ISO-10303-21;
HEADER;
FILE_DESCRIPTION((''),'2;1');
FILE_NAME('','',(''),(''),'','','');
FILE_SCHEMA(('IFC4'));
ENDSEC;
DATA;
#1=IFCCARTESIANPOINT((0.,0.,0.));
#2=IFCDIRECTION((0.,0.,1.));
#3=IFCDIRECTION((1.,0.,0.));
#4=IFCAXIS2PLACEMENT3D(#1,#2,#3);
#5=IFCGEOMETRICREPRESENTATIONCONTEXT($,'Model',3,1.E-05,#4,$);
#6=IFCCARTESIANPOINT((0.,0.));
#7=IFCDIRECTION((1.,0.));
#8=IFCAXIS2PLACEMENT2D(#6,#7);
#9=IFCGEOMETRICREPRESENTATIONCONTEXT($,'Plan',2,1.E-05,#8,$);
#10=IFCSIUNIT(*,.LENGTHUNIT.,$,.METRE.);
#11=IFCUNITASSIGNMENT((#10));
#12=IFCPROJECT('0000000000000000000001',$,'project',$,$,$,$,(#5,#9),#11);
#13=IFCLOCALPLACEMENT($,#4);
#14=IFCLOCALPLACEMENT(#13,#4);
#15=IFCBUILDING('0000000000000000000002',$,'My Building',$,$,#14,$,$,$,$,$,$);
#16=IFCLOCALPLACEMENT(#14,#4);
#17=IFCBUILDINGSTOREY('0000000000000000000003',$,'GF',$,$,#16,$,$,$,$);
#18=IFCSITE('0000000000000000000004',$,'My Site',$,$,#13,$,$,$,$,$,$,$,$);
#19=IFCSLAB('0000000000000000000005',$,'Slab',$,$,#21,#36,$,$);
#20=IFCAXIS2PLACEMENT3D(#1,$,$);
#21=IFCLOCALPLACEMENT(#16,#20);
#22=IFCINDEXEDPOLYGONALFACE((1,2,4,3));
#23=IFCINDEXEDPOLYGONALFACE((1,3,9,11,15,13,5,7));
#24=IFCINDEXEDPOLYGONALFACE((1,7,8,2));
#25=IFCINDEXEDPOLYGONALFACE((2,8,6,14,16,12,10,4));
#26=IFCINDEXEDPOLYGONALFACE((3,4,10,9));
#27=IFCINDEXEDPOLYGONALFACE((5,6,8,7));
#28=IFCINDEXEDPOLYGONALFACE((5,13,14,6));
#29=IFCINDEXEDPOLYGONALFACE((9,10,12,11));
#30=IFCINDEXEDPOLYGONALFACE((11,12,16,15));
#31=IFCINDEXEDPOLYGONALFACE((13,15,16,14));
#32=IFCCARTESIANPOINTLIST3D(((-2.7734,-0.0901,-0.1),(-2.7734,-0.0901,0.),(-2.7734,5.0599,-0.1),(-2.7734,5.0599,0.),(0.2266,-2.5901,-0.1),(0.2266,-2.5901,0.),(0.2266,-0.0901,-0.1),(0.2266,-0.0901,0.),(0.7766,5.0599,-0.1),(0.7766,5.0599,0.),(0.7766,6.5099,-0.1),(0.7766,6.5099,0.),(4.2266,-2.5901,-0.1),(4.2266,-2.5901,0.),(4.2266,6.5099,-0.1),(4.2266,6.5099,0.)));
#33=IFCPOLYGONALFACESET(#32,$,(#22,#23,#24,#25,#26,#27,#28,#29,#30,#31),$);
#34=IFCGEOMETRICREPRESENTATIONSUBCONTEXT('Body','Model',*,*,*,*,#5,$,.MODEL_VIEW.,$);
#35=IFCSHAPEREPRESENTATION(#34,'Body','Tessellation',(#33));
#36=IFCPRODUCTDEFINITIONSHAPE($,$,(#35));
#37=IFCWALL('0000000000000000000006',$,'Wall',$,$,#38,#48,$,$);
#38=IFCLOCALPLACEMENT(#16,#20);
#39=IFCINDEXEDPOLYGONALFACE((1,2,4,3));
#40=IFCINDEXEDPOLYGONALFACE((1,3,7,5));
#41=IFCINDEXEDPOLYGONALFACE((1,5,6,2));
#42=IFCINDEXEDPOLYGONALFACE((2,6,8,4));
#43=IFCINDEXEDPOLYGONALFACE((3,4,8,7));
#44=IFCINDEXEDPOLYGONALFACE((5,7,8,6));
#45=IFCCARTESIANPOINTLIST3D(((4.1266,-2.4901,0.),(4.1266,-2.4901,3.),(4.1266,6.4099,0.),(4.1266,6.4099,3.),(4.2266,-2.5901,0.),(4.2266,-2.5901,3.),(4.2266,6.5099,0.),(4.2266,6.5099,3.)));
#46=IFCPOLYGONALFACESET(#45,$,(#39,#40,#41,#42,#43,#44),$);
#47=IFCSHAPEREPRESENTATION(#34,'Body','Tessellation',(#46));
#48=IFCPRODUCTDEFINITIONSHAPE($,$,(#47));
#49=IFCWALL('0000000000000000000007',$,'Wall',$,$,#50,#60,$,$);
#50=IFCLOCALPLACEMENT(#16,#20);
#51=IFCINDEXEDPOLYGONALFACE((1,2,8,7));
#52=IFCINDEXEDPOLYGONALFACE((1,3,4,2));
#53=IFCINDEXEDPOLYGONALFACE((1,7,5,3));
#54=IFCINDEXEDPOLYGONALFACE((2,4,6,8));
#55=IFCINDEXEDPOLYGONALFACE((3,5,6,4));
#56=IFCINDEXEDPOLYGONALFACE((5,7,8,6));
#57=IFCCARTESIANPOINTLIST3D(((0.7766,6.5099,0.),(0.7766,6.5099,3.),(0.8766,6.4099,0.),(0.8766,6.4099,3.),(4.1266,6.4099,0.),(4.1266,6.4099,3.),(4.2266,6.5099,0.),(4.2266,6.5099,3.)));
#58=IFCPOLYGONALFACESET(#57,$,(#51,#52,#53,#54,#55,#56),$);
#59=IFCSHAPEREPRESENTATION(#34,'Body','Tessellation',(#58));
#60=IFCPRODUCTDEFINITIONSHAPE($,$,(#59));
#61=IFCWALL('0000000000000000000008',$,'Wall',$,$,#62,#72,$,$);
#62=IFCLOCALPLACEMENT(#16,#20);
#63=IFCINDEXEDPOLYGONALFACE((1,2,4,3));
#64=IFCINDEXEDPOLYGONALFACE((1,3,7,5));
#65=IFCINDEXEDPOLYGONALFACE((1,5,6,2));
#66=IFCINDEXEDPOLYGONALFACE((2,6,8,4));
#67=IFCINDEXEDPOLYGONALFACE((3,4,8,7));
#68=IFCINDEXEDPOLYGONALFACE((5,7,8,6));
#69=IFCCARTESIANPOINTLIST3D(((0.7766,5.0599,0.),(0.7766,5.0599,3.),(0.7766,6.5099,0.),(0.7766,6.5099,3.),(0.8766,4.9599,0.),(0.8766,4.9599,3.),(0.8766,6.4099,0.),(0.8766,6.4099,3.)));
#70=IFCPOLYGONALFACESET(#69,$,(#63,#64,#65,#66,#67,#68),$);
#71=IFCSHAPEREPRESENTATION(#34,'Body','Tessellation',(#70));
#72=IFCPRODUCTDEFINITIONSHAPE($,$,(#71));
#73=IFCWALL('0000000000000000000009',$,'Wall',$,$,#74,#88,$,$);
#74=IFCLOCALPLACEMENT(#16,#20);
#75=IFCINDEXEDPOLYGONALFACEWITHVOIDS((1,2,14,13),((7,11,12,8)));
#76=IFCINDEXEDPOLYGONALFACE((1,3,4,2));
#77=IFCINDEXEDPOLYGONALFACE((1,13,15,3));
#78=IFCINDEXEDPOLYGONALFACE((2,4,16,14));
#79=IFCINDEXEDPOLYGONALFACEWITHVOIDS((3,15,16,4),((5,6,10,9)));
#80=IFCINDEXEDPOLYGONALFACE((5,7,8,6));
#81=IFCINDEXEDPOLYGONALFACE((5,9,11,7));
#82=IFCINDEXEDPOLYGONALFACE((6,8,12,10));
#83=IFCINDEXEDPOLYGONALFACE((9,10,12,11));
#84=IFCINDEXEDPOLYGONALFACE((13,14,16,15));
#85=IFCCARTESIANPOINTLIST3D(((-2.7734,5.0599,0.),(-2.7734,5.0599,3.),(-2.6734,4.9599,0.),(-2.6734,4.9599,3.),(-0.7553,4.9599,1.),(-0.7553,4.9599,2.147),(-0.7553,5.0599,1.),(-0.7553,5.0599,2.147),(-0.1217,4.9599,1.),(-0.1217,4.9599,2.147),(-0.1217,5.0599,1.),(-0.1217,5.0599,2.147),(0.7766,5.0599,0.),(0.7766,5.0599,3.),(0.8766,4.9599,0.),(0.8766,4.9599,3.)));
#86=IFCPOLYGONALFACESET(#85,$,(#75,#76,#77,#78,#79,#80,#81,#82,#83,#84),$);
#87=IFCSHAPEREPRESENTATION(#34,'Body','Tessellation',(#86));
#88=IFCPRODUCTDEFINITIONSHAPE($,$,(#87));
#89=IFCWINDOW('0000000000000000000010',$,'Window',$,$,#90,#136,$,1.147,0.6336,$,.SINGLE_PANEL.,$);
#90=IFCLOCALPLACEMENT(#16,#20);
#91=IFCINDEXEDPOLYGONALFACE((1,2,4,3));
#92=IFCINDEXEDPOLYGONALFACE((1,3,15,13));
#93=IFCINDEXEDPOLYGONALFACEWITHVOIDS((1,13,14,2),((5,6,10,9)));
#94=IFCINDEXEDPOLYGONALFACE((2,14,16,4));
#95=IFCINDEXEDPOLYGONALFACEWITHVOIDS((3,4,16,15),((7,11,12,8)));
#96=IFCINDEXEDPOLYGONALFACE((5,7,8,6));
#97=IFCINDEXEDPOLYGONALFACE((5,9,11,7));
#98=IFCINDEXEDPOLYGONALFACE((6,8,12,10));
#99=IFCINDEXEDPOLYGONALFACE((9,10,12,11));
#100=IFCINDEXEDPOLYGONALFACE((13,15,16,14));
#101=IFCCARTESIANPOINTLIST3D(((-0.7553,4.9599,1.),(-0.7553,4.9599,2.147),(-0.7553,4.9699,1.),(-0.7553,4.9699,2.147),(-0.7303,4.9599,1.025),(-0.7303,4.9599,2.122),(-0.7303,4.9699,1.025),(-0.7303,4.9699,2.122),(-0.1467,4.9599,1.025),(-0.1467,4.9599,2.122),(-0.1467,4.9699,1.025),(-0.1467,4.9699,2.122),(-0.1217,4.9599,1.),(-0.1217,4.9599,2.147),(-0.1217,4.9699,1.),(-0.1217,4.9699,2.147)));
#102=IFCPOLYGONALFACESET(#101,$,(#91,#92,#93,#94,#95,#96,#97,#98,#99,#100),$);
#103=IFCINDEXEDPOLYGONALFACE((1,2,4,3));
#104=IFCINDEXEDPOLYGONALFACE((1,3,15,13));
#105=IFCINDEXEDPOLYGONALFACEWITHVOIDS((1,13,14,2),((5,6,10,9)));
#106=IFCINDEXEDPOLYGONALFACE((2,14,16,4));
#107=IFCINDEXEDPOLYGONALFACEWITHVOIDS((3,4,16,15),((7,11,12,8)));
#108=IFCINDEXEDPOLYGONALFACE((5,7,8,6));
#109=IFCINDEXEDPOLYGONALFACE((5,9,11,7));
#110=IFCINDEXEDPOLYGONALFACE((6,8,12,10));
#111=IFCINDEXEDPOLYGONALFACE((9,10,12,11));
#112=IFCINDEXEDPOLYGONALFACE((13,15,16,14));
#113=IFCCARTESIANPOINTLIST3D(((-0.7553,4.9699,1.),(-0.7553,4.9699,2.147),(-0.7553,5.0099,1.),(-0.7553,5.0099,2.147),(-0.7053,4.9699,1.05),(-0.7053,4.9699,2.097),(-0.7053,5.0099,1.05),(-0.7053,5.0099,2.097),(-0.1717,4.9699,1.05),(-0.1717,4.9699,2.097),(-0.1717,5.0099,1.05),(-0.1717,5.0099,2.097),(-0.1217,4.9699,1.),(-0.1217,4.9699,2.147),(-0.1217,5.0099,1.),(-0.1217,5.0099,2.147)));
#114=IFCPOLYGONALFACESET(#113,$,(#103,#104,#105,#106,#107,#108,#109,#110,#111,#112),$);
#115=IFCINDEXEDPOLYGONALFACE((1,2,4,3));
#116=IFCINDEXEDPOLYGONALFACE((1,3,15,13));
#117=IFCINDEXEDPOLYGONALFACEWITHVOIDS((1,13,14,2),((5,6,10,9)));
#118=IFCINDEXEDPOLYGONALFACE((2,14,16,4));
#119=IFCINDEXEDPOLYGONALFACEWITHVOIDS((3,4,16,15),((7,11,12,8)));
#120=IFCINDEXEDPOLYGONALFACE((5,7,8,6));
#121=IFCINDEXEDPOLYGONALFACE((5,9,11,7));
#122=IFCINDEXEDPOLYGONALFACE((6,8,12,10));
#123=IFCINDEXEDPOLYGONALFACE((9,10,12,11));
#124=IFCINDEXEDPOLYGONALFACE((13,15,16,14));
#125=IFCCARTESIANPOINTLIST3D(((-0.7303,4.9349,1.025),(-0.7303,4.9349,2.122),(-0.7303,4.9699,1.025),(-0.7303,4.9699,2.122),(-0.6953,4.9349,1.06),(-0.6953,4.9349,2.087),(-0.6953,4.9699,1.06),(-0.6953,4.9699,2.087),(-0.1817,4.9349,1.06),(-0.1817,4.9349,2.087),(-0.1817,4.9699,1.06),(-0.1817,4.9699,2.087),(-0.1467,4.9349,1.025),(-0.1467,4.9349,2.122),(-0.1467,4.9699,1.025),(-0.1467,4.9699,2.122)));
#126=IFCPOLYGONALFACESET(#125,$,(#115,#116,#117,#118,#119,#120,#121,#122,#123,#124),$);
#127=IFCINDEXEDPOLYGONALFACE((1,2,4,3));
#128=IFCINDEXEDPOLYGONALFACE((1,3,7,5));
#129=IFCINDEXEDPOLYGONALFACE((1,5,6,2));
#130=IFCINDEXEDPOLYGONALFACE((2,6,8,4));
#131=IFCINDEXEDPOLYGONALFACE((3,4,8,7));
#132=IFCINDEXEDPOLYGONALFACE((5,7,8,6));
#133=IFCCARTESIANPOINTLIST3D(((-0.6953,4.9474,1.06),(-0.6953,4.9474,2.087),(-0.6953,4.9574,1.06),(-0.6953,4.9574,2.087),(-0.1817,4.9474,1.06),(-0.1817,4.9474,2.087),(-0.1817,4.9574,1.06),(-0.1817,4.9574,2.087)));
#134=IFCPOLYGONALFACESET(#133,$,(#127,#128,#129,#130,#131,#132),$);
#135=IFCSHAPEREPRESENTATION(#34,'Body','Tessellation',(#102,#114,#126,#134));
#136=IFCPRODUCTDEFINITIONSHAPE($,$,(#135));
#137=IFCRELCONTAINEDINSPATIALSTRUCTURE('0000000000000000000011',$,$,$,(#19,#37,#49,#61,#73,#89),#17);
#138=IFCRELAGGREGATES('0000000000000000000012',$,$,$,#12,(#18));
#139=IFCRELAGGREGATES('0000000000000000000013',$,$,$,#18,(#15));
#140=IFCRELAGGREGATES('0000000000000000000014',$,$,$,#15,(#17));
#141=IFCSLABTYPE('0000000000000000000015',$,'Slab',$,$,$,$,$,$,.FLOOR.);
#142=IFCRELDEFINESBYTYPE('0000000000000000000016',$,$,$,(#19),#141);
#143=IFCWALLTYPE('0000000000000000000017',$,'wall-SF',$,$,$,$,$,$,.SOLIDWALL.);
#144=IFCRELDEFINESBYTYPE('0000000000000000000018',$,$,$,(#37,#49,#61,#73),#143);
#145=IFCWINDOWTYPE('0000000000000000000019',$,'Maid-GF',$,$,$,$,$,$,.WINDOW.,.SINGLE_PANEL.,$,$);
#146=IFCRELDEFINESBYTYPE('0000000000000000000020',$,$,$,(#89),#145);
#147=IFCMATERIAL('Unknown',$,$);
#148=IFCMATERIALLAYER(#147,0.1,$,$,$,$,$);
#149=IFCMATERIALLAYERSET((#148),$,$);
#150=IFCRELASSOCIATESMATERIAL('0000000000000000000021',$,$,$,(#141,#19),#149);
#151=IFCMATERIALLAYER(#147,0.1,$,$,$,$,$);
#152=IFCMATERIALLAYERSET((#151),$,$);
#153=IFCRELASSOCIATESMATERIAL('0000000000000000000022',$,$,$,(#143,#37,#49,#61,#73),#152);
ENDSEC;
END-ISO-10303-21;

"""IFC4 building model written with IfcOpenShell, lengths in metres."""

from ifc_helpers import new_model, entity, si_unit, frame, origin_with_axes, origin_2d_with_axis, place, context, subcontext, project, spatial, line, indexed_curve, outline, extrude, shape, source, transform, mapped, material, layer, layer_set, layer_usage, type_object, type_shapes, element, fill, save


model = new_model("IFC4")

# Units and contexts
model_context = context("Model", 3, precision=1e-05, world=origin_with_axes())
plan_context = context("Plan", 2, precision=1e-05, world=origin_2d_with_axis())
body_context_1 = subcontext(model_context, "Body", "Model", "MODEL_VIEW")
body_context_2 = subcontext(plan_context, "Body", "Plan", "PLAN_VIEW")
ifc_project = project(units=[si_unit("LENGTHUNIT", "METRE")], contexts=[model_context, plan_context])

# Site, building, storey
site_placement = place(None, origin_with_axes())
site = spatial("IfcSite", under=ifc_project, at=site_placement, Name="My Site")
building_placement = place(site_placement, origin_with_axes())
building = spatial("IfcBuilding", under=site, at=building_placement, Name="My Building")
storey_placement = place(building_placement, origin_with_axes())
storey = spatial("IfcBuildingStorey", under=building, at=storey_placement, Name="GF")

# Slab
ifc_material = material(Name="Unknown")
ifc_layer_1 = layer(ifc_material, 0.1)
ifc_layer_set_1 = layer_set([ifc_layer_1])
ifc_layer_usage_1 = layer_usage(ifc_layer_set_1, "AXIS3", "POSITIVE", -0.1)
slab_type = type_object("IfcSlabType", Name="Slab", PredefinedType="FLOOR", material=ifc_layer_set_1)
slab_placement = place(storey_placement, frame((4.2266, -2.5901, 0.0), z_axis=(0.0, 0.0, 1.0), x_axis=(1.0, 0.0, 0.0)))
element("IfcSlab", 1, at=slab_placement, inside=storey, type_object=slab_type, material=ifc_layer_usage_1, Name="Slab", context=body_context_1, shape_type="SweptSolid", body=[
    extrude(outline(indexed_curve([(0.0, 0.0), (0.0, 9.1), (-3.45, 9.1), (-3.45, 7.65), (-7.0, 7.65), (-7.0, 2.5), (-4.0, 2.5), (-4.0, 0.0), (0.0, 0.0)])), frame((0.0, 0.0, -0.1), z_axis=(0.0, 0.0, 1.0), x_axis=(1.0, 0.0, 0.0)), (0.0, 0.0, 1.0), 0.1),
])

# Shared definitions
ifc_layer_2 = layer(ifc_material, 0.1)
ifc_layer_set_2 = layer_set([ifc_layer_2])
wall_type = type_object("IfcWallType", Name="wall-SF", PredefinedType="SOLIDWALL", material=ifc_layer_set_2)

# Walls
ifc_layer_usage_2 = layer_usage(ifc_layer_set_2, "AXIS2", "POSITIVE", 0.0)
wall_1_placement = place(storey_placement, frame((4.2266, -2.5901, 0.0), z_axis=(0.0, 0.0, 1.0), x_axis=(0.0, 1.0, 0.0)))
element("IfcWall", 2, at=wall_1_placement, inside=storey, type_object=wall_type, material=ifc_layer_usage_2, Name="Wall", context=body_context_1, shape_type="SweptSolid", body=[
    extrude(outline(indexed_curve([(0.0, 0.0), (0.1, 0.1), (9.0, 0.1), (9.1, 0.0)], segments=[line(1, 2, 3, 4, 1)])), origin_with_axes(), (0.0, 0.0, 1.0), 3.0),
])
ifc_layer_usage_3 = layer_usage(ifc_layer_set_2, "AXIS2", "POSITIVE", 0.0)
wall_2_placement = place(storey_placement, frame((4.2266, 6.5099, 0.0), z_axis=(0.0, 0.0, 1.0), x_axis=(-1.0, 0.0, 0.0)))
element("IfcWall", 3, at=wall_2_placement, inside=storey, type_object=wall_type, material=ifc_layer_usage_3, Name="Wall", context=body_context_1, shape_type="SweptSolid", body=[
    extrude(outline(indexed_curve([(0.0, 0.0), (0.1, 0.1), (3.35, 0.1), (3.45, 0.0)], segments=[line(1, 2, 3, 4, 1)])), origin_with_axes(), (0.0, 0.0, 1.0), 3.0),
])
ifc_layer_usage_4 = layer_usage(ifc_layer_set_2, "AXIS2", "POSITIVE", 0.0)
wall_3_placement = place(storey_placement, frame((0.7766, 6.5099, 0.0), z_axis=(0.0, 0.0, 1.0), x_axis=(0.0, -1.0, 0.0)))
element("IfcWall", 4, at=wall_3_placement, inside=storey, type_object=wall_type, material=ifc_layer_usage_4, Name="Wall", context=body_context_1, shape_type="SweptSolid", body=[
    extrude(outline(indexed_curve([(0.0, 0.0), (0.1, 0.1), (1.55, 0.1), (1.45, 0.0)], segments=[line(1, 2, 3, 4, 1)])), origin_with_axes(), (0.0, 0.0, 1.0), 3.0),
])

# Wall, opening, window
ifc_layer_usage_5 = layer_usage(ifc_layer_set_2, "AXIS2", "POSITIVE", 0.0)
wall_4_placement = place(storey_placement, frame((0.7766, 5.0599, 0.0), z_axis=(0.0, 0.0, 1.0), x_axis=(-1.0, 0.0, 0.0)))
wall_4 = element("IfcWall", 5, at=wall_4_placement, inside=storey, type_object=wall_type, material=ifc_layer_usage_5, Name="Wall", context=body_context_1, shape_type="SweptSolid", body=[
    extrude(outline(indexed_curve([(0.0, 0.0), (-0.1, 0.1), (3.45, 0.1), (3.55, 0.0)], segments=[line(1, 2, 3, 4, 1)])), origin_with_axes(), (0.0, 0.0, 1.0), 3.0),
])
shared_shape_1 = source(origin_with_axes(), body_context_1, "Body", "SweptSolid", [
    extrude(outline(indexed_curve([(0.0, 0.0), (0.6336, 0.0), (0.6336, 1.147), (0.0, 1.147)], segments=[line(1, 2, 3, 4, 1)])), frame((0.0, -0.6, 0.0), z_axis=(0.0, -1.0, 0.0), x_axis=(1.0, 0.0, 0.0)), (0.0, 0.0, -1.0), 1.2),
])
opening_1_placement = place(wall_4_placement, frame((0.8983, 0.0, 1.0), z_axis=(0.0, 0.0, 1.0), x_axis=(1.0, 0.0, 0.0)))
opening_1 = element("IfcOpeningElement", 6, at=opening_1_placement, cuts=wall_4, PredefinedType="OPENING", context=body_context_1, shape_type="MappedRepresentation", body=[
    mapped(shared_shape_1, transform((0.0, 0.0, 0.0), x_axis=(1.0, 0.0, 0.0), y_axis=(0.0, 1.0, 0.0), z_axis=(0.0, 0.0, 1.0), scale=1.0)),
])
window_type_1 = type_object("IfcWindowType", Name="Maid-GF", PartitioningType="SINGLE_PANEL", PredefinedType="WINDOW")
shared_shape_2 = source(origin_with_axes(), body_context_1, "Body", "SweptSolid", [
    extrude(outline(indexed_curve([(0.0, 0.0), (0.6336, 0.0), (0.6336, 1.147), (0.0, 1.147)], segments=[line(1, 2, 3, 4, 1)]), holes=[indexed_curve([(0.025, 0.025), (0.6086, 0.025), (0.6086, 1.122), (0.025, 1.122)], segments=[line(1, 2, 3, 4, 1)])]), frame((0.0, 0.09, 0.0), z_axis=(0.0, -1.0, 0.0), x_axis=(1.0, 0.0, 0.0)), (0.0, 0.0, -1.0), 0.01),
    extrude(outline(indexed_curve([(0.0, 0.0), (0.6336, 0.0), (0.6336, 1.147), (0.0, 1.147)], segments=[line(1, 2, 3, 4, 1)]), holes=[indexed_curve([(0.05, 0.05), (0.5836, 0.05), (0.5836, 1.097), (0.05, 1.097)], segments=[line(1, 2, 3, 4, 1)])]), frame((0.0, 0.05, 0.0), z_axis=(0.0, -1.0, 0.0), x_axis=(1.0, 0.0, 0.0)), (0.0, 0.0, -1.0), 0.04),
    extrude(outline(indexed_curve([(0.0, 0.0), (0.5836, 0.0), (0.5836, 1.097), (0.0, 1.097)], segments=[line(1, 2, 3, 4, 1)]), holes=[indexed_curve([(0.035, 0.035), (0.5486, 0.035), (0.5486, 1.062), (0.035, 1.062)], segments=[line(1, 2, 3, 4, 1)])]), frame((0.025, 0.09, 0.025), z_axis=(0.0, -1.0, 0.0), x_axis=(1.0, 0.0, 0.0)), (0.0, 0.0, -1.0), 0.035),
    extrude(outline(indexed_curve([(0.035, 0.035), (0.5486, 0.035), (0.5486, 1.062), (0.035, 1.062)], segments=[line(1, 2, 3, 4, 1)])), frame((0.025, 0.1025, 0.025), z_axis=(0.0, -1.0, 0.0), x_axis=(1.0, 0.0, 0.0)), (0.0, 0.0, -1.0), 0.01),
])
shared_shape_3 = source(origin_with_axes(), body_context_2, "Body", "Curve2D", [
    entity("IfcIndexedPolyCurve", entity("IfcCartesianPointList2D", [[0.05, 0.05], [0.5836, 0.05]])),
    entity("IfcIndexedPolyCurve", entity("IfcCartesianPointList2D", [[0.0, 0.1], [0.025, 0.1], [0.025, 0.09], [0.05, 0.09], [0.05, 0.05], [0.0, 0.05]]), [entity("IfcLineIndex", [1, 2, 3, 4, 5, 6, 1])]),
    entity("IfcIndexedPolyCurve", entity("IfcCartesianPointList2D", [[0.6336, 0.1], [0.6086, 0.1], [0.6086, 0.09], [0.5836, 0.09], [0.5836, 0.05], [0.6336, 0.05]]), [entity("IfcLineIndex", [1, 2, 3, 4, 5, 6, 1])]),
    entity("IfcIndexedPolyCurve", entity("IfcCartesianPointList2D", [[0.025, 0.09], [0.06, 0.09], [0.06, 0.125], [0.025, 0.125]]), [entity("IfcLineIndex", [1, 2, 3, 4, 1])]),
    entity("IfcIndexedPolyCurve", entity("IfcCartesianPointList2D", [[0.6086, 0.09], [0.5736, 0.09], [0.5736, 0.125], [0.6086, 0.125]]), [entity("IfcLineIndex", [1, 2, 3, 4, 1])]),
    entity("IfcIndexedPolyCurve", entity("IfcCartesianPointList2D", [[0.06, 0.09], [0.5736, 0.09]])),
    entity("IfcIndexedPolyCurve", entity("IfcCartesianPointList2D", [[0.06, 0.125], [0.5736, 0.125]])),
    entity("IfcIndexedPolyCurve", entity("IfcCartesianPointList2D", [[0.06, 0.1075], [0.5736, 0.1075]])),
])
type_shapes(window_type_1, [shared_shape_2, shared_shape_3])
window_1_placement = place(opening_1_placement, frame((0.0, 0.0, 0.0), z_axis=(0.0, 0.0, 1.0), x_axis=(1.0, 0.0, 0.0)))
window_1 = element("IfcWindow", 7, at=window_1_placement, inside=storey, type_object=window_type_1, Name="Window", OverallHeight=1.147, OverallWidth=0.6336, PartitioningType="SINGLE_PANEL", shapes=[
    shape(body_context_1, "Body", "MappedRepresentation", [mapped(shared_shape_2, transform((0.0, 0.0, 0.0), x_axis=(1.0, 0.0, 0.0), y_axis=(0.0, 1.0, 0.0), z_axis=(0.0, 0.0, 1.0), scale=1.0))]),
    shape(body_context_2, "Body", "MappedRepresentation", [mapped(shared_shape_3, transform((0.0, 0.0, 0.0), x_axis=(1.0, 0.0, 0.0), y_axis=(0.0, 1.0, 0.0), z_axis=(0.0, 0.0, 1.0), scale=1.0))]),
])
fill(opening_1, window_1)

save(model, "model.ifc")
